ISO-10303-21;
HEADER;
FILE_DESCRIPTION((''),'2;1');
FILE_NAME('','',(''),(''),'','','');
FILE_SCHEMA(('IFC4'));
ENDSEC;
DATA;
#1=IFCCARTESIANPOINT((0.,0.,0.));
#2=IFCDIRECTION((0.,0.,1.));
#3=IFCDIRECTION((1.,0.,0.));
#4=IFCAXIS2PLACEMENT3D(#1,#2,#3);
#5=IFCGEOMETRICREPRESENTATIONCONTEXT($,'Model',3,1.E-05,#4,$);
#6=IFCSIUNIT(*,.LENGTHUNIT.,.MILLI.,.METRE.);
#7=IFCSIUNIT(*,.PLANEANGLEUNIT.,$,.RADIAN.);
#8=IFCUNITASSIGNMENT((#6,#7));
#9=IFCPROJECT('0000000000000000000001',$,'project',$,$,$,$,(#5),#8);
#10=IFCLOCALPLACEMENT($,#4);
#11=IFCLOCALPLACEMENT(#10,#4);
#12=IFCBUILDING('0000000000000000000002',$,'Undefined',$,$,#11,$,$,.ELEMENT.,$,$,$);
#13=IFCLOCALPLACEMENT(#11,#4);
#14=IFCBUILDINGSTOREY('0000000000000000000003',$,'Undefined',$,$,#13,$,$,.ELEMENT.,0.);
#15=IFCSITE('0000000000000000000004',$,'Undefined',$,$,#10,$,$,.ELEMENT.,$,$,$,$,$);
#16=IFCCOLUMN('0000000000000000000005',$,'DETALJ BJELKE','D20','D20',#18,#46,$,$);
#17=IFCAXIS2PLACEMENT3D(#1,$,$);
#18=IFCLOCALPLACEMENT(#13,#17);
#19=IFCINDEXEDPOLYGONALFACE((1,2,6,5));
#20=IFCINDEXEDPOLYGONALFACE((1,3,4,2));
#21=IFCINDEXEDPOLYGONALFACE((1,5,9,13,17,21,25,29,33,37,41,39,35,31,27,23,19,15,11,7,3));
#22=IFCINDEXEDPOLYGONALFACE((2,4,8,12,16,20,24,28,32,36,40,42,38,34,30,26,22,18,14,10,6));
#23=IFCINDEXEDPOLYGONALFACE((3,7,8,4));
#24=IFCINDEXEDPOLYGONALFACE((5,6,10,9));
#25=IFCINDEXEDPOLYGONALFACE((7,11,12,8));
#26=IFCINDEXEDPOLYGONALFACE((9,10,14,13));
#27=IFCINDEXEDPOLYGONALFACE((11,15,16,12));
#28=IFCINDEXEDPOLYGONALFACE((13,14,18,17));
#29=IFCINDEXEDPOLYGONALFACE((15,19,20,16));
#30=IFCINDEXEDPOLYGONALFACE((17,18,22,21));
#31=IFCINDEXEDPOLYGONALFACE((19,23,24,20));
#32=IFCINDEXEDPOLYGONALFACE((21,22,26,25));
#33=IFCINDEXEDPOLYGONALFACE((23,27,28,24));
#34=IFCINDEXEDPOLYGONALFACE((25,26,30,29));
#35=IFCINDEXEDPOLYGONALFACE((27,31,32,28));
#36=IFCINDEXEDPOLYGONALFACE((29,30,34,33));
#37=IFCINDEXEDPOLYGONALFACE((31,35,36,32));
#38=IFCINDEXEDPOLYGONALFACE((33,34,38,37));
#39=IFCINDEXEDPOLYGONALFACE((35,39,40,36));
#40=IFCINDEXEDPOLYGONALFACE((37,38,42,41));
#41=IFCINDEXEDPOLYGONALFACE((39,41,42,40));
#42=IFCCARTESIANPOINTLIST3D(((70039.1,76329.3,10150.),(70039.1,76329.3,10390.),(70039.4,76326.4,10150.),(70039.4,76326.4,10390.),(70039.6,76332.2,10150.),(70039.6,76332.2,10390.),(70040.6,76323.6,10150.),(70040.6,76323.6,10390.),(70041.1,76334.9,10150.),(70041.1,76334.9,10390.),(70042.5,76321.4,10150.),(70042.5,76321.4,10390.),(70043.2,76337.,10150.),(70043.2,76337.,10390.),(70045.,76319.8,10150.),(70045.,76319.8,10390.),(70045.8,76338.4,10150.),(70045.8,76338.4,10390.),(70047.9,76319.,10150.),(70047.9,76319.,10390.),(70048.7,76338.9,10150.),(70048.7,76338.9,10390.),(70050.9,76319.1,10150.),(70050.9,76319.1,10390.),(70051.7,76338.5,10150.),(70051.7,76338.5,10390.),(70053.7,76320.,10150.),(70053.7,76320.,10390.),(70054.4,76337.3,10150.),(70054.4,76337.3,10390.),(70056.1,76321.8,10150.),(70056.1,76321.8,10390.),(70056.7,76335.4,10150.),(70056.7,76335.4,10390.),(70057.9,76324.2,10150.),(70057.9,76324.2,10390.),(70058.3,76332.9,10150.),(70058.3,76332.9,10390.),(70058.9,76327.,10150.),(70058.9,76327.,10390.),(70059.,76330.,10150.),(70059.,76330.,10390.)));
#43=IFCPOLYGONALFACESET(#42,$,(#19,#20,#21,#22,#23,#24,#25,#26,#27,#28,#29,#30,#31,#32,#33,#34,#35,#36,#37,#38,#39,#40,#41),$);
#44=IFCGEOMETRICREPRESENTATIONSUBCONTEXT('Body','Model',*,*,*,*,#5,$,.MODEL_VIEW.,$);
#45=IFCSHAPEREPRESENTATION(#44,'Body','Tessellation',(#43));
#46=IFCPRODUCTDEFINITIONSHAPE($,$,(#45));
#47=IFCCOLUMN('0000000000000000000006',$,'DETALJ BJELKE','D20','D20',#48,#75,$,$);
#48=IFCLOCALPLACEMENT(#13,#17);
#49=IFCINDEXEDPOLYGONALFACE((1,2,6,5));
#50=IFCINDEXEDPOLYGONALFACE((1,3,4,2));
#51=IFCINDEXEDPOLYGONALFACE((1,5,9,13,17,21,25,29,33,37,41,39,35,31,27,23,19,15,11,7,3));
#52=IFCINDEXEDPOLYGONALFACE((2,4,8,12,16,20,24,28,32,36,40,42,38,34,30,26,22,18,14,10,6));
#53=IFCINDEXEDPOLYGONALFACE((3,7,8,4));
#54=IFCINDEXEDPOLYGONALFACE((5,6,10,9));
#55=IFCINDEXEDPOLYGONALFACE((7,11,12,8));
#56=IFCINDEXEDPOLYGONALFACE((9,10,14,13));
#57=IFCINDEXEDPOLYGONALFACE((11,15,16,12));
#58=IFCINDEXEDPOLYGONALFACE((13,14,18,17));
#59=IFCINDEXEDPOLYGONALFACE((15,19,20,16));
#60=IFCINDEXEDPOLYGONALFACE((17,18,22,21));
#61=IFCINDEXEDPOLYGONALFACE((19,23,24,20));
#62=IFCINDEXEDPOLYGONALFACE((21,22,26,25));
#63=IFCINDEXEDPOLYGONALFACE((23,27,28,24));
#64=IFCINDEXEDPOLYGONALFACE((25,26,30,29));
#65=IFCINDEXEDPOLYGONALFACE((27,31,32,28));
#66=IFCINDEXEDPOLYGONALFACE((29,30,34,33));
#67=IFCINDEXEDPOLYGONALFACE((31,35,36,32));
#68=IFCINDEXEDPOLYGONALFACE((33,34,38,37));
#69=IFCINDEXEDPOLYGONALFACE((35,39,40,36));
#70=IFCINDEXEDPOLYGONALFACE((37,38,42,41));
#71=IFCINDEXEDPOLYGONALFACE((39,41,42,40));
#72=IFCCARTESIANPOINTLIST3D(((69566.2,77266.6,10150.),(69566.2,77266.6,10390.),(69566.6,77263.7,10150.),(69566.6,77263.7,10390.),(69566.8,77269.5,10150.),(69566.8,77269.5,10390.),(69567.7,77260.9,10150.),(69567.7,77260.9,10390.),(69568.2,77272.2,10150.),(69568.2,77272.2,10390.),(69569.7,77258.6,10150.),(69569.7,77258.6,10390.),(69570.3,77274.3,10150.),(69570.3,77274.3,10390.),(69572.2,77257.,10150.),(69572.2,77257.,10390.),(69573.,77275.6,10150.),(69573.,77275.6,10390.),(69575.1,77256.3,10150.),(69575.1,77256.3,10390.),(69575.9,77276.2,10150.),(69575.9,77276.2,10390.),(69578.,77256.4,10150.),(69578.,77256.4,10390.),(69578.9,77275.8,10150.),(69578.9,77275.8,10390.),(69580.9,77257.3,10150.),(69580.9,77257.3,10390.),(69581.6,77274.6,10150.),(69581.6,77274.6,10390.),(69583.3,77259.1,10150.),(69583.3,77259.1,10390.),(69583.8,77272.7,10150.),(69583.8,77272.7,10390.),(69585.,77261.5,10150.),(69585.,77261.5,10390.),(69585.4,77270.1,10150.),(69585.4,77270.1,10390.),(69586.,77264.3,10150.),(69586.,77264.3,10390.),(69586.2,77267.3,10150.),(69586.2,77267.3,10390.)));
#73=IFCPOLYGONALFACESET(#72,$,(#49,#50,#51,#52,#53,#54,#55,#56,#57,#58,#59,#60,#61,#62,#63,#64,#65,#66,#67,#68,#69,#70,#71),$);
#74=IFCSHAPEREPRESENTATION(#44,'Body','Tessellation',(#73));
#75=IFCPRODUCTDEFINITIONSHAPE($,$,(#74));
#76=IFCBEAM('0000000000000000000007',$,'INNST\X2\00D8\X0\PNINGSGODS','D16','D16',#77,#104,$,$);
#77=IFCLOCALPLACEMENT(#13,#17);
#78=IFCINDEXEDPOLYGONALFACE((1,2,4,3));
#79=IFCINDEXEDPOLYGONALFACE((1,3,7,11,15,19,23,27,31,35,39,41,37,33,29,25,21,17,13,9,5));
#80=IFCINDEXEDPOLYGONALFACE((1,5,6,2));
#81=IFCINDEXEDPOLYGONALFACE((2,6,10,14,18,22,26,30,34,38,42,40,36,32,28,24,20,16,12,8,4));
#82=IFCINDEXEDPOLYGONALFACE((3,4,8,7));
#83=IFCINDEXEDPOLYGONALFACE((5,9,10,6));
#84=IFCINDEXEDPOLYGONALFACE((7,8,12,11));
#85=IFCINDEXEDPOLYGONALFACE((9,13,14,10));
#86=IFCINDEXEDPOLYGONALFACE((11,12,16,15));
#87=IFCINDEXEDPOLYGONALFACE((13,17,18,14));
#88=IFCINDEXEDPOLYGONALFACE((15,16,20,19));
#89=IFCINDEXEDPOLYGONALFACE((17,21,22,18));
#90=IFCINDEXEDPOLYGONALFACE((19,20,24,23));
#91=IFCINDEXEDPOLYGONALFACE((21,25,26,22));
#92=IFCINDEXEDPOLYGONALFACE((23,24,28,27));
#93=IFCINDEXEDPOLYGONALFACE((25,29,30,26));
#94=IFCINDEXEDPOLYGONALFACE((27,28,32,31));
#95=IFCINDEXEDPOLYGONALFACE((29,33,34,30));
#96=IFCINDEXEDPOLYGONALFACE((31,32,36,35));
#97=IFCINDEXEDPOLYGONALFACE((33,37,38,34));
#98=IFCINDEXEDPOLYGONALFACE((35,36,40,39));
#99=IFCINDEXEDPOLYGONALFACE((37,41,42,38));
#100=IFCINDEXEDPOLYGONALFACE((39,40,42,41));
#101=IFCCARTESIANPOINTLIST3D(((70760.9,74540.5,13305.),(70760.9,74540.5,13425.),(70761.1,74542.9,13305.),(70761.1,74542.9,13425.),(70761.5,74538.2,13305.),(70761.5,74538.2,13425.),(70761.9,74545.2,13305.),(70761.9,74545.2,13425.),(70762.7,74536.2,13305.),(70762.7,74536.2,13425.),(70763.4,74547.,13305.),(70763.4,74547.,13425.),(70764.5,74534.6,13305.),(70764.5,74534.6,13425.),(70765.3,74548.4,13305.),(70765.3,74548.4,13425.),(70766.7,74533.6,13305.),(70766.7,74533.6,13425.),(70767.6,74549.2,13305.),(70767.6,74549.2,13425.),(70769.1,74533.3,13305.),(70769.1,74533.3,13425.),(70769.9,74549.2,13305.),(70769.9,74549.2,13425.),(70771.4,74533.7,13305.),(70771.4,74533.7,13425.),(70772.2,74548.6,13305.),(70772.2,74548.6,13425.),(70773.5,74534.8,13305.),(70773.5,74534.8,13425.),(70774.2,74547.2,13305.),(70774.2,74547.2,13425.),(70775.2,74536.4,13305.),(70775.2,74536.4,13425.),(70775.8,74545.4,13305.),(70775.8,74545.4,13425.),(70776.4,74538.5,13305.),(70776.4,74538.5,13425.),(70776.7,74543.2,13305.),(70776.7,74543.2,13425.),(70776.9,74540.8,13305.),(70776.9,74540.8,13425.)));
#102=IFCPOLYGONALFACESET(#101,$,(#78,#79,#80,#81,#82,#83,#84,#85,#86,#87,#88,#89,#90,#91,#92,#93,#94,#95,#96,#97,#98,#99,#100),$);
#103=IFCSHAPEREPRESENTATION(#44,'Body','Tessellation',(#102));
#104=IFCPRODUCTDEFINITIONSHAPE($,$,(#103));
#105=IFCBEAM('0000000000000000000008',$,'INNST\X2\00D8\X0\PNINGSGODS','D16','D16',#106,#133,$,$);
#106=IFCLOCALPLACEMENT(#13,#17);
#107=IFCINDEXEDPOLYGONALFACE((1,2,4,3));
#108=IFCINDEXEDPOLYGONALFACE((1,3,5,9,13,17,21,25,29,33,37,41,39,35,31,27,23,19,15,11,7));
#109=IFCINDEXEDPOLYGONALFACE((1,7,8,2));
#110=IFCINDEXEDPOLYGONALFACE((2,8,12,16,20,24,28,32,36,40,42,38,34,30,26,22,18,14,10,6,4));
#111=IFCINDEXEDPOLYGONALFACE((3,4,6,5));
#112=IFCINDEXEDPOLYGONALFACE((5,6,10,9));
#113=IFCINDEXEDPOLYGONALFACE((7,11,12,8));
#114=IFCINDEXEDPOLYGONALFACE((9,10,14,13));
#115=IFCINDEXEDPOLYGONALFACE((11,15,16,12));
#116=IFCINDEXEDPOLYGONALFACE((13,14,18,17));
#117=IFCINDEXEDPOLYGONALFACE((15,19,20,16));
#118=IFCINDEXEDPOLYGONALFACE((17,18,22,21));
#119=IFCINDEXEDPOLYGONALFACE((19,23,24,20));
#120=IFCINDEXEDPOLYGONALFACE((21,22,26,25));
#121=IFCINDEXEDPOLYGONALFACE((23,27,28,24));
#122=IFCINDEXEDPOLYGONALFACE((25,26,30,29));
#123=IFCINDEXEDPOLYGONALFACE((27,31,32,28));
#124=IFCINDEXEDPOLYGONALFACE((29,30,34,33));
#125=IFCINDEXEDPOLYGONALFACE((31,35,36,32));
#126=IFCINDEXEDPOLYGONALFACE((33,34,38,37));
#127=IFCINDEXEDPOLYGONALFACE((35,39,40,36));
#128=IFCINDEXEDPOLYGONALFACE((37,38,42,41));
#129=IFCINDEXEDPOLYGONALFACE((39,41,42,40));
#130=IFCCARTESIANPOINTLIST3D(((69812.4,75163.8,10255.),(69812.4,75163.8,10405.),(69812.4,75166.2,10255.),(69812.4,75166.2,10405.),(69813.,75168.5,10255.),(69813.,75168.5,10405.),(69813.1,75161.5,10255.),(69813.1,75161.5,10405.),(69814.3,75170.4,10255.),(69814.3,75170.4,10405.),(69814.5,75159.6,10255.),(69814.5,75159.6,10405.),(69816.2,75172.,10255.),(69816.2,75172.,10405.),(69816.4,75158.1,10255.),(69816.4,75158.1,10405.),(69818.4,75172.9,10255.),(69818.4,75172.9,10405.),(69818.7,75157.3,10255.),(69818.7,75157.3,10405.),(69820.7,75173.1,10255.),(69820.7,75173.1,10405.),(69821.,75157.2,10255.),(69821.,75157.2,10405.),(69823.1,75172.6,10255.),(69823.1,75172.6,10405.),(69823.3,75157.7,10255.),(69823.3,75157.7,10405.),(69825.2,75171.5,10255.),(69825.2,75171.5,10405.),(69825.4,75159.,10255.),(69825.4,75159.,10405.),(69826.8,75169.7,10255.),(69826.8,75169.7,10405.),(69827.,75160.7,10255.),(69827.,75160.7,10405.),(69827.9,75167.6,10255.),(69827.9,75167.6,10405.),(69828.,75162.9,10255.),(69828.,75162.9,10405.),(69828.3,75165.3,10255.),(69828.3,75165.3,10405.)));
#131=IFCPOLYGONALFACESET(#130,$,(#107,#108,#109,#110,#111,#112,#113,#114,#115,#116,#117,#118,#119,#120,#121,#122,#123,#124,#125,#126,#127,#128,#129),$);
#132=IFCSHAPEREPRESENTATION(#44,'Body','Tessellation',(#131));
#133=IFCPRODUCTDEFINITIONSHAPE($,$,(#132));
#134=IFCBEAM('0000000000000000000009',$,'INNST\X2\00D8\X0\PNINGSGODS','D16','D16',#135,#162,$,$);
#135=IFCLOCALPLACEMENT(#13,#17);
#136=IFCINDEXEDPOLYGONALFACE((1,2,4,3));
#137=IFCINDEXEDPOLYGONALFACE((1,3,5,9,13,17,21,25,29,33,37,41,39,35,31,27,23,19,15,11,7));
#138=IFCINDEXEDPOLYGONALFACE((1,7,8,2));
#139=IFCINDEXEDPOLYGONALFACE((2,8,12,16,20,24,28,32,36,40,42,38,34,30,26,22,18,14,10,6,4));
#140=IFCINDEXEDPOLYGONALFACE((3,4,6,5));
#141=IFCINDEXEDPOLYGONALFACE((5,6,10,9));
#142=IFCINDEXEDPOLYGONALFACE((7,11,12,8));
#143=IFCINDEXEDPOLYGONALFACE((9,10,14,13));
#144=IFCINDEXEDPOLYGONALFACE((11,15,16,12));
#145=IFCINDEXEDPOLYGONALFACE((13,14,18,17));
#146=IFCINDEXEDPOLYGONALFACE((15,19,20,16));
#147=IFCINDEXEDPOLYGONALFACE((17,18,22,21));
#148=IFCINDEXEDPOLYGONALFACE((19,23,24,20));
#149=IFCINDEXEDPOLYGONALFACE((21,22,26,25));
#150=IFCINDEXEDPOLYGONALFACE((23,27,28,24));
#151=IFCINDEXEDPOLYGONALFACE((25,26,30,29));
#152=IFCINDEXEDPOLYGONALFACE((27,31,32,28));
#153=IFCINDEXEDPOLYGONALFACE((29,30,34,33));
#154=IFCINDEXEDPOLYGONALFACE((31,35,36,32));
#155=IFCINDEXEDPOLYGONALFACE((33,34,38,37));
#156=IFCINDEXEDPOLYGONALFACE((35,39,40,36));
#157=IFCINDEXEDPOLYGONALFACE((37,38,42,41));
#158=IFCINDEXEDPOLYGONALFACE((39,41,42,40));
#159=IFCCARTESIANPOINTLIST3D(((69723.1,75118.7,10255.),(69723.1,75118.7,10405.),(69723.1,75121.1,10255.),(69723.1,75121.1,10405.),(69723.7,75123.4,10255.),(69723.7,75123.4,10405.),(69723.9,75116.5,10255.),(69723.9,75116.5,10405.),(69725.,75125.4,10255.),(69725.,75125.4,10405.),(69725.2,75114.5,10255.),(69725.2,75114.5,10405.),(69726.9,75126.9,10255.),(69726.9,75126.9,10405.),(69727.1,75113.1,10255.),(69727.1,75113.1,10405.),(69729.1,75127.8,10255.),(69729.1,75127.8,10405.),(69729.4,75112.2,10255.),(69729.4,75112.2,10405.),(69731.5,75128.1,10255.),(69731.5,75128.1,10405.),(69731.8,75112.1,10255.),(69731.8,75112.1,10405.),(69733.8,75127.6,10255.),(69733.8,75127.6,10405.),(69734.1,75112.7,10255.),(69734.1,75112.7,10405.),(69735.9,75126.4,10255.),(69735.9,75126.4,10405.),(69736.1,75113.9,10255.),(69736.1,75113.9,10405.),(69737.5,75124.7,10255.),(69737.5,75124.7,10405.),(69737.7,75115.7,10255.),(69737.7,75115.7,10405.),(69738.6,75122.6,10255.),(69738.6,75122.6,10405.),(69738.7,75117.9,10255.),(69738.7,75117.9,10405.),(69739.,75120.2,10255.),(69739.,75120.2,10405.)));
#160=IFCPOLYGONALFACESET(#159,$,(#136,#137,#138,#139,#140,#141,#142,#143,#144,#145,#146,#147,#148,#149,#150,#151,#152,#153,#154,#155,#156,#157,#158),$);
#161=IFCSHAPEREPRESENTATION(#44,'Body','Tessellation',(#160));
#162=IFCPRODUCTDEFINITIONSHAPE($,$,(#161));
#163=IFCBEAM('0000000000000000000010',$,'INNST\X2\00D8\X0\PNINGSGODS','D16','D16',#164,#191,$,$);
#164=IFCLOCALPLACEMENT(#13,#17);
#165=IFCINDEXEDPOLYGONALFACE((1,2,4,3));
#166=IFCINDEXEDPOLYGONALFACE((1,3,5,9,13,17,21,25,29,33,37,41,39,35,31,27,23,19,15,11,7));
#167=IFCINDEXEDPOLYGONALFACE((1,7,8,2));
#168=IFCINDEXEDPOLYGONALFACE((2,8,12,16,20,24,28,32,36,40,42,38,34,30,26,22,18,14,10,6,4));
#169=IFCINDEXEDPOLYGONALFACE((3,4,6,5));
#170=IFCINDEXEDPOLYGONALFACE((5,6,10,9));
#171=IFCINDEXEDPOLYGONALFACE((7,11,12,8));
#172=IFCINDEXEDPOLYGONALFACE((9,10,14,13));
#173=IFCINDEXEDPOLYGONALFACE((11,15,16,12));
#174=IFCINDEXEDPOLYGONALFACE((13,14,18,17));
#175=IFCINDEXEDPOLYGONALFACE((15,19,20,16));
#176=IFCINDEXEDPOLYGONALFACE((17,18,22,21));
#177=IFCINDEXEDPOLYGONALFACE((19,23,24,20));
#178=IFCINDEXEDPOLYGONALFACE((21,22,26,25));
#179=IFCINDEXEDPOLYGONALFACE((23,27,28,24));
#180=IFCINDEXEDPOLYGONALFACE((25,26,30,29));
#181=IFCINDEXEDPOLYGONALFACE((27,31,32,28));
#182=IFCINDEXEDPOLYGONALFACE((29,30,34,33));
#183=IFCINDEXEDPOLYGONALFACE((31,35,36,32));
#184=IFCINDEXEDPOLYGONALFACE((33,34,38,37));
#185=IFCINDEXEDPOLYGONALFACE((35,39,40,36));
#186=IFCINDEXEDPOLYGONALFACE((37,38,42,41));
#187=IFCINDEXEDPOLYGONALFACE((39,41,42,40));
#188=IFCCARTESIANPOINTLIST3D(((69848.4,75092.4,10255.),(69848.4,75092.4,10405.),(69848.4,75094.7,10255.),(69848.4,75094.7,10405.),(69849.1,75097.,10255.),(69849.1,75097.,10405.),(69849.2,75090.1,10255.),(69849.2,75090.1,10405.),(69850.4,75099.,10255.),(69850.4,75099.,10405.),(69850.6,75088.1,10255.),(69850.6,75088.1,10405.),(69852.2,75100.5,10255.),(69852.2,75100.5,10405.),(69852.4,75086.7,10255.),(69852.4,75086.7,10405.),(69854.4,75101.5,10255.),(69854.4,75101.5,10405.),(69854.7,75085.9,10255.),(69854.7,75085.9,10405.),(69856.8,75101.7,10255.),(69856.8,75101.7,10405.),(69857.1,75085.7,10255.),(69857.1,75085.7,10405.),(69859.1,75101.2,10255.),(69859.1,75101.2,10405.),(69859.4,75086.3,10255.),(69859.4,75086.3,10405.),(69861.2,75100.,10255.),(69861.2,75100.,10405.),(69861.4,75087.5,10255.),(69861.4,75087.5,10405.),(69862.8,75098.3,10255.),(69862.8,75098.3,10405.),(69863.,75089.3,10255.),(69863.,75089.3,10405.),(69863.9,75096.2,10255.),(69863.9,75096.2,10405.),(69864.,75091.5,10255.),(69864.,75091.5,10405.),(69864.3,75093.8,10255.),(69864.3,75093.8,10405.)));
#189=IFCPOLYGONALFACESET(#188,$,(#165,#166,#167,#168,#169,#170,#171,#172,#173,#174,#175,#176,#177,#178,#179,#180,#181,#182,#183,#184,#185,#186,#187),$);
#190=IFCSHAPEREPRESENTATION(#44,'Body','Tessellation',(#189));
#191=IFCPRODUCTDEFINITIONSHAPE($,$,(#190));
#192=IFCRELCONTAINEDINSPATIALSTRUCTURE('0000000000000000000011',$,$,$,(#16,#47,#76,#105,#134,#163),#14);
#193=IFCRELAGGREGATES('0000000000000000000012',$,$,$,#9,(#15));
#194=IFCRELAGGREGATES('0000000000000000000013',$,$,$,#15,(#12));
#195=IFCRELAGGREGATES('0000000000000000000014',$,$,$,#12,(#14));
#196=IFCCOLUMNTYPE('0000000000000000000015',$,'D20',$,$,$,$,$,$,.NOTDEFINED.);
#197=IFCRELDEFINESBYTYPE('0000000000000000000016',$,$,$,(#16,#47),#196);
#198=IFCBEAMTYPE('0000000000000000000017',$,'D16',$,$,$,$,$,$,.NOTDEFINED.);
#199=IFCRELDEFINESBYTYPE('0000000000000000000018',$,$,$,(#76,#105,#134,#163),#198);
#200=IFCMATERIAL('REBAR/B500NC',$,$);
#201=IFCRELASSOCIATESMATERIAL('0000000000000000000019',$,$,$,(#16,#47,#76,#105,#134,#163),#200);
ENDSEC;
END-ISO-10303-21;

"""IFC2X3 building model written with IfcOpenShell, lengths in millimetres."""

from ifc_helpers import new_model, si_unit, frame, origin_with_axes, origin_2d_with_axis, place, context, subcontext, project, spatial, circle, extrude, material, type_object, element, save


model = new_model("IFC2X3")

# Units and contexts
model_context = context("Model", 3, precision=1e-05, world=origin_with_axes())
body_context = subcontext(model_context, "Body", "Model", "MODEL_VIEW")
ifc_project = project(units=[si_unit("LENGTHUNIT", "METRE", prefix="MILLI"), si_unit("PLANEANGLEUNIT", "RADIAN")], contexts=[model_context])

# Site, building, storey
site_placement = place(None, origin_with_axes())
site = spatial("IfcSite", under=ifc_project, at=site_placement, Name="Undefined", CompositionType="ELEMENT")
building_placement = place(site_placement, origin_with_axes())
building = spatial("IfcBuilding", under=site, at=building_placement, Name="Undefined", CompositionType="ELEMENT")
storey_placement = place(building_placement, origin_with_axes())
storey = spatial("IfcBuildingStorey", under=building, at=storey_placement, Name="Undefined", CompositionType="ELEMENT", Elevation=0.0)

# Columns
ifc_material_1 = material(Name="REBAR/B500NC")
column_type = type_object("IfcColumnType", Name="D20", PredefinedType="NOTDEFINED")
for number, where, z_axis, x_axis, name in (
    (1, (70049.1, 76328.9, 10150.0), (0.0, 0.0, 1.0), (-0.886365, -0.462987, 0.0), "DETALJ BJELKE"),
    (2, (69576.2, 77266.2, 10150.0), (0.0, 0.0, 1.0), (-0.886365, -0.462987, 0.0), "DETALJ BJELKE"),
):
    element("IfcColumn", number, at=place(storey_placement, frame(where, z_axis=z_axis, x_axis=x_axis)), inside=storey, type_object=column_type, material=ifc_material_1, Name=name, Description="D20", ObjectType="D20", context=body_context, shape_type="SweptSolid", body=[
        extrude(circle(Radius=10.0, at=origin_2d_with_axis()), frame((0.0, 0.0, 240.0), z_axis=(0.0, 0.0, -1.0), x_axis=(0.0, 1.0, 0.0)), (0.0, 0.0, 1.0), 240.0),
    ])

# Beams
beam_type = type_object("IfcBeamType", Name="D16", PredefinedType="NOTDEFINED")
beam_placement = place(storey_placement, frame((70768.9, 74541.3, 13425.0), z_axis=(-0.892821, -0.450411, 0.0), x_axis=(0.0, 0.0, -1.0)))
element("IfcBeam", 3, at=beam_placement, inside=storey, type_object=beam_type, material=ifc_material_1, Name="INNSTØPNINGSGODS", Description="D16", ObjectType="D16", context=body_context, shape_type="SweptSolid", body=[
    extrude(circle(Radius=8.0, at=origin_2d_with_axis()), frame((120.0, 0.0, 0.0), z_axis=(-1.0, 0.0, 0.0), x_axis=(0.0, -1.0, 0.0)), (0.0, 0.0, 1.0), 120.0),
])
for number, where, z_axis, x_axis, name in (
    (4, (69820.3, 75165.1, 10405.0), (0.450411, -0.892821, 0.0), (0.0, 0.0, -1.0), "INNSTØPNINGSGODS"),
    (5, (69731.0, 75120.1, 10405.0), (0.450411, -0.892821, 0.0), (0.0, 0.0, -1.0), "INNSTØPNINGSGODS"),
    (6, (69856.3, 75093.7, 10405.0), (0.450411, -0.892821, 0.0), (0.0, 0.0, -1.0), "INNSTØPNINGSGODS"),
):
    element("IfcBeam", number, at=place(storey_placement, frame(where, z_axis=z_axis, x_axis=x_axis)), inside=storey, type_object=beam_type, material=ifc_material_1, Name=name, Description="D16", ObjectType="D16", context=body_context, shape_type="SweptSolid", body=[
        extrude(circle(Radius=8.0, at=origin_2d_with_axis()), frame((150.0, 0.0, 0.0), z_axis=(-1.0, 0.0, 0.0), x_axis=(0.0, -1.0, 0.0)), (0.0, 0.0, 1.0), 150.0),
    ])

save(model, "model.ifc")
